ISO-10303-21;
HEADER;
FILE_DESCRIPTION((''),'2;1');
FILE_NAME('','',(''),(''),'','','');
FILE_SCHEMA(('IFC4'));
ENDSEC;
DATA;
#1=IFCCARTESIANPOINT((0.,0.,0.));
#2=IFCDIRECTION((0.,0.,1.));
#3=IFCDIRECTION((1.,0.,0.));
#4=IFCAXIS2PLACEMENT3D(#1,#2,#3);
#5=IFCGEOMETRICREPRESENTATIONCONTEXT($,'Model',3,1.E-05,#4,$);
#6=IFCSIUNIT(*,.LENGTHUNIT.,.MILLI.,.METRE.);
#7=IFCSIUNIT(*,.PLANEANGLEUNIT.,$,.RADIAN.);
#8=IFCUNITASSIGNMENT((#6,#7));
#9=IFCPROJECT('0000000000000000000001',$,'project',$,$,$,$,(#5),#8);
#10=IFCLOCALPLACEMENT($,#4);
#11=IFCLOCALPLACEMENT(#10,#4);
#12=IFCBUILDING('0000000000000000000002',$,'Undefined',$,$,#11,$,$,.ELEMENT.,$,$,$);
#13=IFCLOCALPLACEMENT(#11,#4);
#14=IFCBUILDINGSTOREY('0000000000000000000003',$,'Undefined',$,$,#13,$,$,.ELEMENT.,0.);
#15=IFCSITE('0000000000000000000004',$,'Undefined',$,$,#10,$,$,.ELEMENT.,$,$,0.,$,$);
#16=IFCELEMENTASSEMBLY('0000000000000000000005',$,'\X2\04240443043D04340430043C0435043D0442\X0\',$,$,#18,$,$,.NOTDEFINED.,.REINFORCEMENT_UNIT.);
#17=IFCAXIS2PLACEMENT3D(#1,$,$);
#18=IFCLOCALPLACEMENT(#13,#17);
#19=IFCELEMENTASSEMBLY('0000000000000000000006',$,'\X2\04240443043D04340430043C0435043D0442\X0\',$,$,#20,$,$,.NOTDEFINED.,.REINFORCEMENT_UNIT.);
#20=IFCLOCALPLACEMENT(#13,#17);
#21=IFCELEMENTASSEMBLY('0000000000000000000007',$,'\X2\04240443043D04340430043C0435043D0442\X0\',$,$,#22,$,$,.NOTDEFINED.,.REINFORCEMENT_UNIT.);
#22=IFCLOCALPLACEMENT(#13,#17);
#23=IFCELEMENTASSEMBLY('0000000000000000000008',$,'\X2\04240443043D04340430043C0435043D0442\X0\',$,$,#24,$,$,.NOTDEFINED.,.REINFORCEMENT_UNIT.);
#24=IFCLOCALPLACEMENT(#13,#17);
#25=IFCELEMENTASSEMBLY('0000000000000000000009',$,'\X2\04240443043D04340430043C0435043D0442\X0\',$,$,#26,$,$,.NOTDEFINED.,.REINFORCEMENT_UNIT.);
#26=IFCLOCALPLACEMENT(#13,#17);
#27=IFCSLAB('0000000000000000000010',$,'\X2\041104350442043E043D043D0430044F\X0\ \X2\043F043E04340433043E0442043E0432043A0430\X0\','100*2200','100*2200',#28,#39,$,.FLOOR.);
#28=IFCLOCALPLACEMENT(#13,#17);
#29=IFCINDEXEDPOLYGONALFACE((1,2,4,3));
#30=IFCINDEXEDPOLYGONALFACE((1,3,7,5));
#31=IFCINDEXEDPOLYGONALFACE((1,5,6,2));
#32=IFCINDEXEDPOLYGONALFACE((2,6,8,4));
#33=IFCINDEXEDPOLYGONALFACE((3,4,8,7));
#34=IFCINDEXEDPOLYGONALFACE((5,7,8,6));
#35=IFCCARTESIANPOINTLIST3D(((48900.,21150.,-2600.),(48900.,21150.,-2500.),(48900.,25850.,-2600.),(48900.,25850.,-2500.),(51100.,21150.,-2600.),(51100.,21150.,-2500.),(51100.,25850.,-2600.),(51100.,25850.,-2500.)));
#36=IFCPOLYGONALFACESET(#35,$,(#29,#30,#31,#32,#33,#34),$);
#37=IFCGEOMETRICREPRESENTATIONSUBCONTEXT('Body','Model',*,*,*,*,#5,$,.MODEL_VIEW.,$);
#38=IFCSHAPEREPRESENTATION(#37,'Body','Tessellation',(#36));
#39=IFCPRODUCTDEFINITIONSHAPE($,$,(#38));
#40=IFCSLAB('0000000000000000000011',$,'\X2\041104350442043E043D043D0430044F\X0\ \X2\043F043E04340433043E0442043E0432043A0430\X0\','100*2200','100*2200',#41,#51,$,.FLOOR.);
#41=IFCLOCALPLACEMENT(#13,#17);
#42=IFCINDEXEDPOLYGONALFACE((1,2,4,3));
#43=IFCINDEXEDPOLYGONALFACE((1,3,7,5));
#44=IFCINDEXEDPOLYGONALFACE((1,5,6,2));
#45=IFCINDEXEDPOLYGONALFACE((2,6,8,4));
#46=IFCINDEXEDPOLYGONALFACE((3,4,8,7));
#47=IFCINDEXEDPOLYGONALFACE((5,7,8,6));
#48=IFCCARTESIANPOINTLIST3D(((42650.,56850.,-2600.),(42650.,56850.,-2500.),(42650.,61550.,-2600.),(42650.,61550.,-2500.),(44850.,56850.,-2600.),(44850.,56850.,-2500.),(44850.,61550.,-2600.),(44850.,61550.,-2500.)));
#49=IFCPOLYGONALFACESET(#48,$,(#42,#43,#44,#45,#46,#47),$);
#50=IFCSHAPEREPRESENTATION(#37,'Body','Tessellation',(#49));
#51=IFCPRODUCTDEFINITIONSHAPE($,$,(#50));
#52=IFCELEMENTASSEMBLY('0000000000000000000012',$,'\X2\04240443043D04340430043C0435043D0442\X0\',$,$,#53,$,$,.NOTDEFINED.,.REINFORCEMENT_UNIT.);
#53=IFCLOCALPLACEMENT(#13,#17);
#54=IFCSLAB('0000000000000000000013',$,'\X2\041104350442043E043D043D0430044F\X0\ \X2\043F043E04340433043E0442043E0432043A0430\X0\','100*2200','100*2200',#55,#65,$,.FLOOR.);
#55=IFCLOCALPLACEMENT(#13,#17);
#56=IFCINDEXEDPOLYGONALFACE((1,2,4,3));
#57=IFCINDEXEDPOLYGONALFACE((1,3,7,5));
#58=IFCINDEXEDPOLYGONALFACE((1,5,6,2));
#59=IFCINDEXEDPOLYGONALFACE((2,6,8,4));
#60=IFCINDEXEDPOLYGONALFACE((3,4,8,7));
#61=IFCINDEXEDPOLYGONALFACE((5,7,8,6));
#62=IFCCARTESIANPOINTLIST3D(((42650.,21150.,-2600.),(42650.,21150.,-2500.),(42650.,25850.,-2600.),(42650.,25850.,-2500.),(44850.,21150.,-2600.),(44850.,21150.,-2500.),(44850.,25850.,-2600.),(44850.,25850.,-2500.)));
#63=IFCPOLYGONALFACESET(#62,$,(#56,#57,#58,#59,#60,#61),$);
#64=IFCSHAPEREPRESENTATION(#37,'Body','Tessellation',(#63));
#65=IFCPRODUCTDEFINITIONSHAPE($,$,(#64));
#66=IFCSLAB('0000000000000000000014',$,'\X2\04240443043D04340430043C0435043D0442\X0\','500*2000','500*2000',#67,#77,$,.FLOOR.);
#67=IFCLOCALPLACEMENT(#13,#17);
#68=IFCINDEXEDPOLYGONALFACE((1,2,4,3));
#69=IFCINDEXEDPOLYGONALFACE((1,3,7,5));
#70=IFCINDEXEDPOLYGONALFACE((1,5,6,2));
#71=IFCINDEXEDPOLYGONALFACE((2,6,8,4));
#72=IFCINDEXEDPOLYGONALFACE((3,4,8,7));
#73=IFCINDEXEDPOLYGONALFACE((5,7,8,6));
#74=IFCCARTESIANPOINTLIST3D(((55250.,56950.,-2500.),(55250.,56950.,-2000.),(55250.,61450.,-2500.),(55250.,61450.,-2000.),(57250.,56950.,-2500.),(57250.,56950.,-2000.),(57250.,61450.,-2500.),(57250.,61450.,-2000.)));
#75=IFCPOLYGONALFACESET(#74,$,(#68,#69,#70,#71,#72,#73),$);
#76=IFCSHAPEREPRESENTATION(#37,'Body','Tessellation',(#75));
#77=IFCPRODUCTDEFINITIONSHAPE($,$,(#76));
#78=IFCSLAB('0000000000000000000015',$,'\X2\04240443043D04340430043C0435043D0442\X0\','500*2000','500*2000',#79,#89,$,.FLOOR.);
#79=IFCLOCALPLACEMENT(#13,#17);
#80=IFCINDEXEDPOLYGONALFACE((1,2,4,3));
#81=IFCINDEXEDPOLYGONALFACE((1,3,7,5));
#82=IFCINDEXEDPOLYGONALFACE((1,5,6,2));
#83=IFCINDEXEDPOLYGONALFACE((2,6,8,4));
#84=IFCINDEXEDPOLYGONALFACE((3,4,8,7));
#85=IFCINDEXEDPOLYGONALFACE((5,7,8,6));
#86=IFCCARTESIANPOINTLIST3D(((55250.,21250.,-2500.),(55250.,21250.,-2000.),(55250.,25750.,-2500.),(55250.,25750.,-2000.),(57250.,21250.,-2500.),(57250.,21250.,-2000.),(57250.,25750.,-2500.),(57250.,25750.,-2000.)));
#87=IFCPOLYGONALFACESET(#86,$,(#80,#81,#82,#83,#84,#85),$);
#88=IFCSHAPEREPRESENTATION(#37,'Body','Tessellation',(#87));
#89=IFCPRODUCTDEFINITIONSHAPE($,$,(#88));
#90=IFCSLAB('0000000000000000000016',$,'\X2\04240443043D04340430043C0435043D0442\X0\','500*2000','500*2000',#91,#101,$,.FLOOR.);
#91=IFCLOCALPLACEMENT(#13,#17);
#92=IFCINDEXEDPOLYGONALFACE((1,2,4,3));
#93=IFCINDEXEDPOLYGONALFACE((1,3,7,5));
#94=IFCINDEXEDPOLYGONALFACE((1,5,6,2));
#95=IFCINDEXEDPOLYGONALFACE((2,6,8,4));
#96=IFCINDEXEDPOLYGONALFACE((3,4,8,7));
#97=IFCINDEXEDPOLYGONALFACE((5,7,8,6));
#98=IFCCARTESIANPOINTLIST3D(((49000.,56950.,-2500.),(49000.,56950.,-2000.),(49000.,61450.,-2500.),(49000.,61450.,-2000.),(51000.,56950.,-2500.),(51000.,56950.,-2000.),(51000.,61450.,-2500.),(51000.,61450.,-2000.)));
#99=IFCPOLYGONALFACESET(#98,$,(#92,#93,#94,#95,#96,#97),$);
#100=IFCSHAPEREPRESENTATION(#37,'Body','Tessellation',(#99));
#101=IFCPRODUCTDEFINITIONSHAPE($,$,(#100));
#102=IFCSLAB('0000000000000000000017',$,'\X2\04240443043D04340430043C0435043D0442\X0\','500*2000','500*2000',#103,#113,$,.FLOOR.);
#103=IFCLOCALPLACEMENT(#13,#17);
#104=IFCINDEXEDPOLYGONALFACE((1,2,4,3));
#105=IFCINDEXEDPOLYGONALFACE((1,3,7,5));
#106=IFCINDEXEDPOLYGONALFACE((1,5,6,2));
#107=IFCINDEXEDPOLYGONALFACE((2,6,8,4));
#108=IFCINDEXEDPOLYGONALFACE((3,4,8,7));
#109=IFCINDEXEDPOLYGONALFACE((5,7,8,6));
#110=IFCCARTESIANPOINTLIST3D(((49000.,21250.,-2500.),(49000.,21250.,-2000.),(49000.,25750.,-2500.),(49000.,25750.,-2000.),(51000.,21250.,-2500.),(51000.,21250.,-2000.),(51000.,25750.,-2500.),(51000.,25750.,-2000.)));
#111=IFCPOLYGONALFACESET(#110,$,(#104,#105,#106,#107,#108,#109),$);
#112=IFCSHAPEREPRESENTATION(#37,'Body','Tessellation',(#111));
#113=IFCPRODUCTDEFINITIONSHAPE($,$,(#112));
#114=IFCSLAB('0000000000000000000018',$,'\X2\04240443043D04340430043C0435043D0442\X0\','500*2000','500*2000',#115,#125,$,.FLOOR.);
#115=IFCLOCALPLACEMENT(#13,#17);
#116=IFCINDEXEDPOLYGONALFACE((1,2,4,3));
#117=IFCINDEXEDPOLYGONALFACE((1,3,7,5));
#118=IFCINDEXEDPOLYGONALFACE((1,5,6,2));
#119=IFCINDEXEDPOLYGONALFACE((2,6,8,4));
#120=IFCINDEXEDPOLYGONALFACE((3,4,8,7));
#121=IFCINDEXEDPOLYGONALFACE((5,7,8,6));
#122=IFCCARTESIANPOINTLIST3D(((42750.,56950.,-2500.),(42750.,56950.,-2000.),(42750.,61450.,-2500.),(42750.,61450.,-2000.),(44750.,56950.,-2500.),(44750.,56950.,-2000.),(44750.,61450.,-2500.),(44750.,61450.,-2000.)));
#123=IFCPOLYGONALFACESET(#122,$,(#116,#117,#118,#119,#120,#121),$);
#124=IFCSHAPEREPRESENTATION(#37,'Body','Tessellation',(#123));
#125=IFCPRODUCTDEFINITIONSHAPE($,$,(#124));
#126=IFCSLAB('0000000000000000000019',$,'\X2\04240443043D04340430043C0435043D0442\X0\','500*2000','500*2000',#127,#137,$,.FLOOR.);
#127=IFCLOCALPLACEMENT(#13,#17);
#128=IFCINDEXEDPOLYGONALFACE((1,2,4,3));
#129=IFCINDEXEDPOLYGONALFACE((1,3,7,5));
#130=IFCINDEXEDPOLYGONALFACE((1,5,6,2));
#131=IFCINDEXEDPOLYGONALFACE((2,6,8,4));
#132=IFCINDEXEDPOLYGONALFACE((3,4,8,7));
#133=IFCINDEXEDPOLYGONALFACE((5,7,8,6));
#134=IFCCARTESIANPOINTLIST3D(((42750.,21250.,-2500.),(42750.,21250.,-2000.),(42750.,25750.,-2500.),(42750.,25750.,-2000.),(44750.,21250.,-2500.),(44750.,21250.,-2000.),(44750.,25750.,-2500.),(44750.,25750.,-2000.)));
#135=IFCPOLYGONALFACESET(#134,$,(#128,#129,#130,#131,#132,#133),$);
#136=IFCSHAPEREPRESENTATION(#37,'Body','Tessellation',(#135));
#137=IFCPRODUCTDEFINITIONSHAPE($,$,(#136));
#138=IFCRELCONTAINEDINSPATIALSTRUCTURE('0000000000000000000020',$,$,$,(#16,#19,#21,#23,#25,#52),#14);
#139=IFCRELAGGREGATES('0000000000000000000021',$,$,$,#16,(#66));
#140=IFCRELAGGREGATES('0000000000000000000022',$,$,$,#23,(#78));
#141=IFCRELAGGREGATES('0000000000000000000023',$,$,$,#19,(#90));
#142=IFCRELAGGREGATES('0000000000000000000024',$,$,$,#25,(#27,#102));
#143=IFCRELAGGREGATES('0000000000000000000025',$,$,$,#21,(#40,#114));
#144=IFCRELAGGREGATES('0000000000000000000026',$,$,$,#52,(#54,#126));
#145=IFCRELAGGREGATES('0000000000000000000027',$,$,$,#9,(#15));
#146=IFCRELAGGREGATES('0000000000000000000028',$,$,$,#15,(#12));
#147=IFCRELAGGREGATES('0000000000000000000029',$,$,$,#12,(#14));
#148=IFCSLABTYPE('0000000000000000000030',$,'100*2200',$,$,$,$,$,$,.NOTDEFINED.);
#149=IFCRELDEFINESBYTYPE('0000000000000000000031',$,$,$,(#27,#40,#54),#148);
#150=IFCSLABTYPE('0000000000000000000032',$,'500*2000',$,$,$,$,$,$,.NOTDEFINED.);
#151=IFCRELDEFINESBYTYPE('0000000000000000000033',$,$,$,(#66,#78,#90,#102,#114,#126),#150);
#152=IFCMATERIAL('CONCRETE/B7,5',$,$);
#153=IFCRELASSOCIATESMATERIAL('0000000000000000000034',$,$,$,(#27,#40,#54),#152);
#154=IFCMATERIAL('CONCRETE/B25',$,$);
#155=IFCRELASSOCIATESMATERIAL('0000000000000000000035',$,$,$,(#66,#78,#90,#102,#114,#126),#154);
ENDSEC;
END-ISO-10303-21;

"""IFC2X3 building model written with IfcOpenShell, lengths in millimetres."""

from ifc_helpers import new_model, si_unit, frame, origin_with_axes, place, context, subcontext, project, spatial, polyline, outline, extrude, material, type_object, element, aggregate, save


model = new_model("IFC2X3")

# Units and contexts
model_context = context("Model", 3, precision=1e-05, world=origin_with_axes())
body_context = subcontext(model_context, "Body", "Model", "MODEL_VIEW")
ifc_project = project(units=[si_unit("LENGTHUNIT", "METRE", prefix="MILLI"), si_unit("PLANEANGLEUNIT", "RADIAN")], contexts=[model_context])

# Site, building, storey
site_placement = place(None, origin_with_axes())
site = spatial("IfcSite", under=ifc_project, at=site_placement, Name="Undefined", CompositionType="ELEMENT", RefElevation=0.0)
building_placement = place(site_placement, origin_with_axes())
building = spatial("IfcBuilding", under=site, at=building_placement, Name="Undefined", CompositionType="ELEMENT")
storey_placement = place(building_placement, origin_with_axes())
storey = spatial("IfcBuildingStorey", under=building, at=storey_placement, Name="Undefined", CompositionType="ELEMENT", Elevation=0.0)

# Element assemblies
assembly_1_placement = place(storey_placement, origin_with_axes())
assembly_1 = element("IfcElementAssembly", 1, at=assembly_1_placement, inside=storey, Name="Фундамент", AssemblyPlace="NOTDEFINED", PredefinedType="REINFORCEMENT_UNIT")
ifc_material_1 = material(Name="CONCRETE/B25")
assembly_2_placement = place(storey_placement, origin_with_axes())
assembly_2 = element("IfcElementAssembly", 2, at=assembly_2_placement, inside=storey, Name="Фундамент", AssemblyPlace="NOTDEFINED", PredefinedType="REINFORCEMENT_UNIT")
assembly_3_placement = place(storey_placement, origin_with_axes())
assembly_3 = element("IfcElementAssembly", 3, at=assembly_3_placement, inside=storey, Name="Фундамент", AssemblyPlace="NOTDEFINED", PredefinedType="REINFORCEMENT_UNIT")

# Shared definitions
ifc_material_2 = material(Name="CONCRETE/B7,5")
slab_type_1 = type_object("IfcSlabType", Name="100*2200", PredefinedType="NOTDEFINED")

# Element assembly
assembly_4_placement = place(storey_placement, origin_with_axes())
assembly_4 = element("IfcElementAssembly", 4, at=assembly_4_placement, inside=storey, Name="Фундамент", AssemblyPlace="NOTDEFINED", PredefinedType="REINFORCEMENT_UNIT")

# Element assembly, slab
assembly_5_placement = place(storey_placement, origin_with_axes())
assembly_5 = element("IfcElementAssembly", 5, at=assembly_5_placement, inside=storey, Name="Фундамент", AssemblyPlace="NOTDEFINED", PredefinedType="REINFORCEMENT_UNIT")
slab_1_placement = place(assembly_5_placement, frame((48900.0, 25850.0, -2550.0), z_axis=(0.0, 0.0, 1.0), x_axis=(0.0, -1.0, 0.0)))
slab_1 = element("IfcSlab", 6, at=slab_1_placement, type_object=slab_type_1, material=ifc_material_2, Name="Бетонная подготовка", Description="100*2200", ObjectType="100*2200", PredefinedType="FLOOR", context=body_context, shape_type="SweptSolid", body=[
    extrude(outline(polyline([(0.0, 0.0), (4700.0, 0.0), (4700.0, 2200.0), (0.0, 2200.0), (0.0, 0.0)])), frame((0.0, 0.0, -50.0), z_axis=(0.0, 0.0, 1.0), x_axis=(1.0, 0.0, 0.0)), (0.0, 0.0, 1.0), 100.0),
])

# Slab
slab_2_placement = place(assembly_3_placement, frame((42650.0, 61550.0, -2550.0), z_axis=(0.0, 0.0, 1.0), x_axis=(0.0, -1.0, 0.0)))
slab_2 = element("IfcSlab", 7, at=slab_2_placement, type_object=slab_type_1, material=ifc_material_2, Name="Бетонная подготовка", Description="100*2200", ObjectType="100*2200", PredefinedType="FLOOR", context=body_context, shape_type="SweptSolid", body=[
    extrude(outline(polyline([(0.0, 0.0), (4700.0, 0.0), (4700.0, 2200.0), (0.0, 2200.0), (0.0, 0.0)])), frame((0.0, 0.0, -50.0), z_axis=(0.0, 0.0, 1.0), x_axis=(1.0, 0.0, 0.0)), (0.0, 0.0, 1.0), 100.0),
])

# Element assembly, slab
assembly_6_placement = place(storey_placement, origin_with_axes())
assembly_6 = element("IfcElementAssembly", 8, at=assembly_6_placement, inside=storey, Name="Фундамент", AssemblyPlace="NOTDEFINED", PredefinedType="REINFORCEMENT_UNIT")
slab_3_placement = place(assembly_6_placement, frame((42650.0, 25850.0, -2550.0), z_axis=(0.0, 0.0, 1.0), x_axis=(0.0, -1.0, 0.0)))
slab_3 = element("IfcSlab", 9, at=slab_3_placement, type_object=slab_type_1, material=ifc_material_2, Name="Бетонная подготовка", Description="100*2200", ObjectType="100*2200", PredefinedType="FLOOR", context=body_context, shape_type="SweptSolid", body=[
    extrude(outline(polyline([(0.0, 0.0), (4700.0, 0.0), (4700.0, 2200.0), (0.0, 2200.0), (0.0, 0.0)])), frame((0.0, 0.0, -50.0), z_axis=(0.0, 0.0, 1.0), x_axis=(1.0, 0.0, 0.0)), (0.0, 0.0, 1.0), 100.0),
])

# Slabs
slab_type_2 = type_object("IfcSlabType", Name="500*2000", PredefinedType="NOTDEFINED")
slab_4_placement = place(assembly_1_placement, frame((55250.0, 61450.0, -2250.0), z_axis=(0.0, 0.0, 1.0), x_axis=(0.0, -1.0, 0.0)))
slab_4 = element("IfcSlab", 10, at=slab_4_placement, type_object=slab_type_2, material=ifc_material_1, Name="Фундамент", Description="500*2000", ObjectType="500*2000", PredefinedType="FLOOR", context=body_context, shape_type="SweptSolid", body=[
    extrude(outline(polyline([(0.0, 0.0), (4500.0, 0.0), (4500.0, 2000.0), (0.0, 2000.0), (0.0, 0.0)])), frame((0.0, 0.0, -250.0), z_axis=(0.0, 0.0, 1.0), x_axis=(1.0, 0.0, 0.0)), (0.0, 0.0, 1.0), 500.0),
])
aggregate(assembly_1, [slab_4])
slab_5_placement = place(assembly_4_placement, frame((55250.0, 25750.0, -2250.0), z_axis=(0.0, 0.0, 1.0), x_axis=(0.0, -1.0, 0.0)))
slab_5 = element("IfcSlab", 11, at=slab_5_placement, type_object=slab_type_2, material=ifc_material_1, Name="Фундамент", Description="500*2000", ObjectType="500*2000", PredefinedType="FLOOR", context=body_context, shape_type="SweptSolid", body=[
    extrude(outline(polyline([(0.0, 0.0), (4500.0, 0.0), (4500.0, 2000.0), (0.0, 2000.0), (0.0, 0.0)])), frame((0.0, 0.0, -250.0), z_axis=(0.0, 0.0, 1.0), x_axis=(1.0, 0.0, 0.0)), (0.0, 0.0, 1.0), 500.0),
])
aggregate(assembly_4, [slab_5])
slab_6_placement = place(assembly_2_placement, frame((49000.0, 61450.0, -2250.0), z_axis=(0.0, 0.0, 1.0), x_axis=(0.0, -1.0, 0.0)))
slab_6 = element("IfcSlab", 12, at=slab_6_placement, type_object=slab_type_2, material=ifc_material_1, Name="Фундамент", Description="500*2000", ObjectType="500*2000", PredefinedType="FLOOR", context=body_context, shape_type="SweptSolid", body=[
    extrude(outline(polyline([(0.0, 0.0), (4500.0, 0.0), (4500.0, 2000.0), (0.0, 2000.0), (0.0, 0.0)])), frame((0.0, 0.0, -250.0), z_axis=(0.0, 0.0, 1.0), x_axis=(1.0, 0.0, 0.0)), (0.0, 0.0, 1.0), 500.0),
])
aggregate(assembly_2, [slab_6])
slab_7_placement = place(assembly_5_placement, frame((49000.0, 25750.0, -2250.0), z_axis=(0.0, 0.0, 1.0), x_axis=(0.0, -1.0, 0.0)))
slab_7 = element("IfcSlab", 13, at=slab_7_placement, type_object=slab_type_2, material=ifc_material_1, Name="Фундамент", Description="500*2000", ObjectType="500*2000", PredefinedType="FLOOR", context=body_context, shape_type="SweptSolid", body=[
    extrude(outline(polyline([(0.0, 0.0), (4500.0, 0.0), (4500.0, 2000.0), (0.0, 2000.0), (0.0, 0.0)])), frame((0.0, 0.0, -250.0), z_axis=(0.0, 0.0, 1.0), x_axis=(1.0, 0.0, 0.0)), (0.0, 0.0, 1.0), 500.0),
])
aggregate(assembly_5, [slab_1, slab_7])
slab_8_placement = place(assembly_3_placement, frame((42750.0, 61450.0, -2250.0), z_axis=(0.0, 0.0, 1.0), x_axis=(0.0, -1.0, 0.0)))
slab_8 = element("IfcSlab", 14, at=slab_8_placement, type_object=slab_type_2, material=ifc_material_1, Name="Фундамент", Description="500*2000", ObjectType="500*2000", PredefinedType="FLOOR", context=body_context, shape_type="SweptSolid", body=[
    extrude(outline(polyline([(0.0, 0.0), (4500.0, 0.0), (4500.0, 2000.0), (0.0, 2000.0), (0.0, 0.0)])), frame((0.0, 0.0, -250.0), z_axis=(0.0, 0.0, 1.0), x_axis=(1.0, 0.0, 0.0)), (0.0, 0.0, 1.0), 500.0),
])
aggregate(assembly_3, [slab_2, slab_8])
slab_9_placement = place(assembly_6_placement, frame((42750.0, 25750.0, -2250.0), z_axis=(0.0, 0.0, 1.0), x_axis=(0.0, -1.0, 0.0)))
slab_9 = element("IfcSlab", 15, at=slab_9_placement, type_object=slab_type_2, material=ifc_material_1, Name="Фундамент", Description="500*2000", ObjectType="500*2000", PredefinedType="FLOOR", context=body_context, shape_type="SweptSolid", body=[
    extrude(outline(polyline([(0.0, 0.0), (4500.0, 0.0), (4500.0, 2000.0), (0.0, 2000.0), (0.0, 0.0)])), frame((0.0, 0.0, -250.0), z_axis=(0.0, 0.0, 1.0), x_axis=(1.0, 0.0, 0.0)), (0.0, 0.0, 1.0), 500.0),
])
aggregate(assembly_6, [slab_3, slab_9])

save(model, "model.ifc")
